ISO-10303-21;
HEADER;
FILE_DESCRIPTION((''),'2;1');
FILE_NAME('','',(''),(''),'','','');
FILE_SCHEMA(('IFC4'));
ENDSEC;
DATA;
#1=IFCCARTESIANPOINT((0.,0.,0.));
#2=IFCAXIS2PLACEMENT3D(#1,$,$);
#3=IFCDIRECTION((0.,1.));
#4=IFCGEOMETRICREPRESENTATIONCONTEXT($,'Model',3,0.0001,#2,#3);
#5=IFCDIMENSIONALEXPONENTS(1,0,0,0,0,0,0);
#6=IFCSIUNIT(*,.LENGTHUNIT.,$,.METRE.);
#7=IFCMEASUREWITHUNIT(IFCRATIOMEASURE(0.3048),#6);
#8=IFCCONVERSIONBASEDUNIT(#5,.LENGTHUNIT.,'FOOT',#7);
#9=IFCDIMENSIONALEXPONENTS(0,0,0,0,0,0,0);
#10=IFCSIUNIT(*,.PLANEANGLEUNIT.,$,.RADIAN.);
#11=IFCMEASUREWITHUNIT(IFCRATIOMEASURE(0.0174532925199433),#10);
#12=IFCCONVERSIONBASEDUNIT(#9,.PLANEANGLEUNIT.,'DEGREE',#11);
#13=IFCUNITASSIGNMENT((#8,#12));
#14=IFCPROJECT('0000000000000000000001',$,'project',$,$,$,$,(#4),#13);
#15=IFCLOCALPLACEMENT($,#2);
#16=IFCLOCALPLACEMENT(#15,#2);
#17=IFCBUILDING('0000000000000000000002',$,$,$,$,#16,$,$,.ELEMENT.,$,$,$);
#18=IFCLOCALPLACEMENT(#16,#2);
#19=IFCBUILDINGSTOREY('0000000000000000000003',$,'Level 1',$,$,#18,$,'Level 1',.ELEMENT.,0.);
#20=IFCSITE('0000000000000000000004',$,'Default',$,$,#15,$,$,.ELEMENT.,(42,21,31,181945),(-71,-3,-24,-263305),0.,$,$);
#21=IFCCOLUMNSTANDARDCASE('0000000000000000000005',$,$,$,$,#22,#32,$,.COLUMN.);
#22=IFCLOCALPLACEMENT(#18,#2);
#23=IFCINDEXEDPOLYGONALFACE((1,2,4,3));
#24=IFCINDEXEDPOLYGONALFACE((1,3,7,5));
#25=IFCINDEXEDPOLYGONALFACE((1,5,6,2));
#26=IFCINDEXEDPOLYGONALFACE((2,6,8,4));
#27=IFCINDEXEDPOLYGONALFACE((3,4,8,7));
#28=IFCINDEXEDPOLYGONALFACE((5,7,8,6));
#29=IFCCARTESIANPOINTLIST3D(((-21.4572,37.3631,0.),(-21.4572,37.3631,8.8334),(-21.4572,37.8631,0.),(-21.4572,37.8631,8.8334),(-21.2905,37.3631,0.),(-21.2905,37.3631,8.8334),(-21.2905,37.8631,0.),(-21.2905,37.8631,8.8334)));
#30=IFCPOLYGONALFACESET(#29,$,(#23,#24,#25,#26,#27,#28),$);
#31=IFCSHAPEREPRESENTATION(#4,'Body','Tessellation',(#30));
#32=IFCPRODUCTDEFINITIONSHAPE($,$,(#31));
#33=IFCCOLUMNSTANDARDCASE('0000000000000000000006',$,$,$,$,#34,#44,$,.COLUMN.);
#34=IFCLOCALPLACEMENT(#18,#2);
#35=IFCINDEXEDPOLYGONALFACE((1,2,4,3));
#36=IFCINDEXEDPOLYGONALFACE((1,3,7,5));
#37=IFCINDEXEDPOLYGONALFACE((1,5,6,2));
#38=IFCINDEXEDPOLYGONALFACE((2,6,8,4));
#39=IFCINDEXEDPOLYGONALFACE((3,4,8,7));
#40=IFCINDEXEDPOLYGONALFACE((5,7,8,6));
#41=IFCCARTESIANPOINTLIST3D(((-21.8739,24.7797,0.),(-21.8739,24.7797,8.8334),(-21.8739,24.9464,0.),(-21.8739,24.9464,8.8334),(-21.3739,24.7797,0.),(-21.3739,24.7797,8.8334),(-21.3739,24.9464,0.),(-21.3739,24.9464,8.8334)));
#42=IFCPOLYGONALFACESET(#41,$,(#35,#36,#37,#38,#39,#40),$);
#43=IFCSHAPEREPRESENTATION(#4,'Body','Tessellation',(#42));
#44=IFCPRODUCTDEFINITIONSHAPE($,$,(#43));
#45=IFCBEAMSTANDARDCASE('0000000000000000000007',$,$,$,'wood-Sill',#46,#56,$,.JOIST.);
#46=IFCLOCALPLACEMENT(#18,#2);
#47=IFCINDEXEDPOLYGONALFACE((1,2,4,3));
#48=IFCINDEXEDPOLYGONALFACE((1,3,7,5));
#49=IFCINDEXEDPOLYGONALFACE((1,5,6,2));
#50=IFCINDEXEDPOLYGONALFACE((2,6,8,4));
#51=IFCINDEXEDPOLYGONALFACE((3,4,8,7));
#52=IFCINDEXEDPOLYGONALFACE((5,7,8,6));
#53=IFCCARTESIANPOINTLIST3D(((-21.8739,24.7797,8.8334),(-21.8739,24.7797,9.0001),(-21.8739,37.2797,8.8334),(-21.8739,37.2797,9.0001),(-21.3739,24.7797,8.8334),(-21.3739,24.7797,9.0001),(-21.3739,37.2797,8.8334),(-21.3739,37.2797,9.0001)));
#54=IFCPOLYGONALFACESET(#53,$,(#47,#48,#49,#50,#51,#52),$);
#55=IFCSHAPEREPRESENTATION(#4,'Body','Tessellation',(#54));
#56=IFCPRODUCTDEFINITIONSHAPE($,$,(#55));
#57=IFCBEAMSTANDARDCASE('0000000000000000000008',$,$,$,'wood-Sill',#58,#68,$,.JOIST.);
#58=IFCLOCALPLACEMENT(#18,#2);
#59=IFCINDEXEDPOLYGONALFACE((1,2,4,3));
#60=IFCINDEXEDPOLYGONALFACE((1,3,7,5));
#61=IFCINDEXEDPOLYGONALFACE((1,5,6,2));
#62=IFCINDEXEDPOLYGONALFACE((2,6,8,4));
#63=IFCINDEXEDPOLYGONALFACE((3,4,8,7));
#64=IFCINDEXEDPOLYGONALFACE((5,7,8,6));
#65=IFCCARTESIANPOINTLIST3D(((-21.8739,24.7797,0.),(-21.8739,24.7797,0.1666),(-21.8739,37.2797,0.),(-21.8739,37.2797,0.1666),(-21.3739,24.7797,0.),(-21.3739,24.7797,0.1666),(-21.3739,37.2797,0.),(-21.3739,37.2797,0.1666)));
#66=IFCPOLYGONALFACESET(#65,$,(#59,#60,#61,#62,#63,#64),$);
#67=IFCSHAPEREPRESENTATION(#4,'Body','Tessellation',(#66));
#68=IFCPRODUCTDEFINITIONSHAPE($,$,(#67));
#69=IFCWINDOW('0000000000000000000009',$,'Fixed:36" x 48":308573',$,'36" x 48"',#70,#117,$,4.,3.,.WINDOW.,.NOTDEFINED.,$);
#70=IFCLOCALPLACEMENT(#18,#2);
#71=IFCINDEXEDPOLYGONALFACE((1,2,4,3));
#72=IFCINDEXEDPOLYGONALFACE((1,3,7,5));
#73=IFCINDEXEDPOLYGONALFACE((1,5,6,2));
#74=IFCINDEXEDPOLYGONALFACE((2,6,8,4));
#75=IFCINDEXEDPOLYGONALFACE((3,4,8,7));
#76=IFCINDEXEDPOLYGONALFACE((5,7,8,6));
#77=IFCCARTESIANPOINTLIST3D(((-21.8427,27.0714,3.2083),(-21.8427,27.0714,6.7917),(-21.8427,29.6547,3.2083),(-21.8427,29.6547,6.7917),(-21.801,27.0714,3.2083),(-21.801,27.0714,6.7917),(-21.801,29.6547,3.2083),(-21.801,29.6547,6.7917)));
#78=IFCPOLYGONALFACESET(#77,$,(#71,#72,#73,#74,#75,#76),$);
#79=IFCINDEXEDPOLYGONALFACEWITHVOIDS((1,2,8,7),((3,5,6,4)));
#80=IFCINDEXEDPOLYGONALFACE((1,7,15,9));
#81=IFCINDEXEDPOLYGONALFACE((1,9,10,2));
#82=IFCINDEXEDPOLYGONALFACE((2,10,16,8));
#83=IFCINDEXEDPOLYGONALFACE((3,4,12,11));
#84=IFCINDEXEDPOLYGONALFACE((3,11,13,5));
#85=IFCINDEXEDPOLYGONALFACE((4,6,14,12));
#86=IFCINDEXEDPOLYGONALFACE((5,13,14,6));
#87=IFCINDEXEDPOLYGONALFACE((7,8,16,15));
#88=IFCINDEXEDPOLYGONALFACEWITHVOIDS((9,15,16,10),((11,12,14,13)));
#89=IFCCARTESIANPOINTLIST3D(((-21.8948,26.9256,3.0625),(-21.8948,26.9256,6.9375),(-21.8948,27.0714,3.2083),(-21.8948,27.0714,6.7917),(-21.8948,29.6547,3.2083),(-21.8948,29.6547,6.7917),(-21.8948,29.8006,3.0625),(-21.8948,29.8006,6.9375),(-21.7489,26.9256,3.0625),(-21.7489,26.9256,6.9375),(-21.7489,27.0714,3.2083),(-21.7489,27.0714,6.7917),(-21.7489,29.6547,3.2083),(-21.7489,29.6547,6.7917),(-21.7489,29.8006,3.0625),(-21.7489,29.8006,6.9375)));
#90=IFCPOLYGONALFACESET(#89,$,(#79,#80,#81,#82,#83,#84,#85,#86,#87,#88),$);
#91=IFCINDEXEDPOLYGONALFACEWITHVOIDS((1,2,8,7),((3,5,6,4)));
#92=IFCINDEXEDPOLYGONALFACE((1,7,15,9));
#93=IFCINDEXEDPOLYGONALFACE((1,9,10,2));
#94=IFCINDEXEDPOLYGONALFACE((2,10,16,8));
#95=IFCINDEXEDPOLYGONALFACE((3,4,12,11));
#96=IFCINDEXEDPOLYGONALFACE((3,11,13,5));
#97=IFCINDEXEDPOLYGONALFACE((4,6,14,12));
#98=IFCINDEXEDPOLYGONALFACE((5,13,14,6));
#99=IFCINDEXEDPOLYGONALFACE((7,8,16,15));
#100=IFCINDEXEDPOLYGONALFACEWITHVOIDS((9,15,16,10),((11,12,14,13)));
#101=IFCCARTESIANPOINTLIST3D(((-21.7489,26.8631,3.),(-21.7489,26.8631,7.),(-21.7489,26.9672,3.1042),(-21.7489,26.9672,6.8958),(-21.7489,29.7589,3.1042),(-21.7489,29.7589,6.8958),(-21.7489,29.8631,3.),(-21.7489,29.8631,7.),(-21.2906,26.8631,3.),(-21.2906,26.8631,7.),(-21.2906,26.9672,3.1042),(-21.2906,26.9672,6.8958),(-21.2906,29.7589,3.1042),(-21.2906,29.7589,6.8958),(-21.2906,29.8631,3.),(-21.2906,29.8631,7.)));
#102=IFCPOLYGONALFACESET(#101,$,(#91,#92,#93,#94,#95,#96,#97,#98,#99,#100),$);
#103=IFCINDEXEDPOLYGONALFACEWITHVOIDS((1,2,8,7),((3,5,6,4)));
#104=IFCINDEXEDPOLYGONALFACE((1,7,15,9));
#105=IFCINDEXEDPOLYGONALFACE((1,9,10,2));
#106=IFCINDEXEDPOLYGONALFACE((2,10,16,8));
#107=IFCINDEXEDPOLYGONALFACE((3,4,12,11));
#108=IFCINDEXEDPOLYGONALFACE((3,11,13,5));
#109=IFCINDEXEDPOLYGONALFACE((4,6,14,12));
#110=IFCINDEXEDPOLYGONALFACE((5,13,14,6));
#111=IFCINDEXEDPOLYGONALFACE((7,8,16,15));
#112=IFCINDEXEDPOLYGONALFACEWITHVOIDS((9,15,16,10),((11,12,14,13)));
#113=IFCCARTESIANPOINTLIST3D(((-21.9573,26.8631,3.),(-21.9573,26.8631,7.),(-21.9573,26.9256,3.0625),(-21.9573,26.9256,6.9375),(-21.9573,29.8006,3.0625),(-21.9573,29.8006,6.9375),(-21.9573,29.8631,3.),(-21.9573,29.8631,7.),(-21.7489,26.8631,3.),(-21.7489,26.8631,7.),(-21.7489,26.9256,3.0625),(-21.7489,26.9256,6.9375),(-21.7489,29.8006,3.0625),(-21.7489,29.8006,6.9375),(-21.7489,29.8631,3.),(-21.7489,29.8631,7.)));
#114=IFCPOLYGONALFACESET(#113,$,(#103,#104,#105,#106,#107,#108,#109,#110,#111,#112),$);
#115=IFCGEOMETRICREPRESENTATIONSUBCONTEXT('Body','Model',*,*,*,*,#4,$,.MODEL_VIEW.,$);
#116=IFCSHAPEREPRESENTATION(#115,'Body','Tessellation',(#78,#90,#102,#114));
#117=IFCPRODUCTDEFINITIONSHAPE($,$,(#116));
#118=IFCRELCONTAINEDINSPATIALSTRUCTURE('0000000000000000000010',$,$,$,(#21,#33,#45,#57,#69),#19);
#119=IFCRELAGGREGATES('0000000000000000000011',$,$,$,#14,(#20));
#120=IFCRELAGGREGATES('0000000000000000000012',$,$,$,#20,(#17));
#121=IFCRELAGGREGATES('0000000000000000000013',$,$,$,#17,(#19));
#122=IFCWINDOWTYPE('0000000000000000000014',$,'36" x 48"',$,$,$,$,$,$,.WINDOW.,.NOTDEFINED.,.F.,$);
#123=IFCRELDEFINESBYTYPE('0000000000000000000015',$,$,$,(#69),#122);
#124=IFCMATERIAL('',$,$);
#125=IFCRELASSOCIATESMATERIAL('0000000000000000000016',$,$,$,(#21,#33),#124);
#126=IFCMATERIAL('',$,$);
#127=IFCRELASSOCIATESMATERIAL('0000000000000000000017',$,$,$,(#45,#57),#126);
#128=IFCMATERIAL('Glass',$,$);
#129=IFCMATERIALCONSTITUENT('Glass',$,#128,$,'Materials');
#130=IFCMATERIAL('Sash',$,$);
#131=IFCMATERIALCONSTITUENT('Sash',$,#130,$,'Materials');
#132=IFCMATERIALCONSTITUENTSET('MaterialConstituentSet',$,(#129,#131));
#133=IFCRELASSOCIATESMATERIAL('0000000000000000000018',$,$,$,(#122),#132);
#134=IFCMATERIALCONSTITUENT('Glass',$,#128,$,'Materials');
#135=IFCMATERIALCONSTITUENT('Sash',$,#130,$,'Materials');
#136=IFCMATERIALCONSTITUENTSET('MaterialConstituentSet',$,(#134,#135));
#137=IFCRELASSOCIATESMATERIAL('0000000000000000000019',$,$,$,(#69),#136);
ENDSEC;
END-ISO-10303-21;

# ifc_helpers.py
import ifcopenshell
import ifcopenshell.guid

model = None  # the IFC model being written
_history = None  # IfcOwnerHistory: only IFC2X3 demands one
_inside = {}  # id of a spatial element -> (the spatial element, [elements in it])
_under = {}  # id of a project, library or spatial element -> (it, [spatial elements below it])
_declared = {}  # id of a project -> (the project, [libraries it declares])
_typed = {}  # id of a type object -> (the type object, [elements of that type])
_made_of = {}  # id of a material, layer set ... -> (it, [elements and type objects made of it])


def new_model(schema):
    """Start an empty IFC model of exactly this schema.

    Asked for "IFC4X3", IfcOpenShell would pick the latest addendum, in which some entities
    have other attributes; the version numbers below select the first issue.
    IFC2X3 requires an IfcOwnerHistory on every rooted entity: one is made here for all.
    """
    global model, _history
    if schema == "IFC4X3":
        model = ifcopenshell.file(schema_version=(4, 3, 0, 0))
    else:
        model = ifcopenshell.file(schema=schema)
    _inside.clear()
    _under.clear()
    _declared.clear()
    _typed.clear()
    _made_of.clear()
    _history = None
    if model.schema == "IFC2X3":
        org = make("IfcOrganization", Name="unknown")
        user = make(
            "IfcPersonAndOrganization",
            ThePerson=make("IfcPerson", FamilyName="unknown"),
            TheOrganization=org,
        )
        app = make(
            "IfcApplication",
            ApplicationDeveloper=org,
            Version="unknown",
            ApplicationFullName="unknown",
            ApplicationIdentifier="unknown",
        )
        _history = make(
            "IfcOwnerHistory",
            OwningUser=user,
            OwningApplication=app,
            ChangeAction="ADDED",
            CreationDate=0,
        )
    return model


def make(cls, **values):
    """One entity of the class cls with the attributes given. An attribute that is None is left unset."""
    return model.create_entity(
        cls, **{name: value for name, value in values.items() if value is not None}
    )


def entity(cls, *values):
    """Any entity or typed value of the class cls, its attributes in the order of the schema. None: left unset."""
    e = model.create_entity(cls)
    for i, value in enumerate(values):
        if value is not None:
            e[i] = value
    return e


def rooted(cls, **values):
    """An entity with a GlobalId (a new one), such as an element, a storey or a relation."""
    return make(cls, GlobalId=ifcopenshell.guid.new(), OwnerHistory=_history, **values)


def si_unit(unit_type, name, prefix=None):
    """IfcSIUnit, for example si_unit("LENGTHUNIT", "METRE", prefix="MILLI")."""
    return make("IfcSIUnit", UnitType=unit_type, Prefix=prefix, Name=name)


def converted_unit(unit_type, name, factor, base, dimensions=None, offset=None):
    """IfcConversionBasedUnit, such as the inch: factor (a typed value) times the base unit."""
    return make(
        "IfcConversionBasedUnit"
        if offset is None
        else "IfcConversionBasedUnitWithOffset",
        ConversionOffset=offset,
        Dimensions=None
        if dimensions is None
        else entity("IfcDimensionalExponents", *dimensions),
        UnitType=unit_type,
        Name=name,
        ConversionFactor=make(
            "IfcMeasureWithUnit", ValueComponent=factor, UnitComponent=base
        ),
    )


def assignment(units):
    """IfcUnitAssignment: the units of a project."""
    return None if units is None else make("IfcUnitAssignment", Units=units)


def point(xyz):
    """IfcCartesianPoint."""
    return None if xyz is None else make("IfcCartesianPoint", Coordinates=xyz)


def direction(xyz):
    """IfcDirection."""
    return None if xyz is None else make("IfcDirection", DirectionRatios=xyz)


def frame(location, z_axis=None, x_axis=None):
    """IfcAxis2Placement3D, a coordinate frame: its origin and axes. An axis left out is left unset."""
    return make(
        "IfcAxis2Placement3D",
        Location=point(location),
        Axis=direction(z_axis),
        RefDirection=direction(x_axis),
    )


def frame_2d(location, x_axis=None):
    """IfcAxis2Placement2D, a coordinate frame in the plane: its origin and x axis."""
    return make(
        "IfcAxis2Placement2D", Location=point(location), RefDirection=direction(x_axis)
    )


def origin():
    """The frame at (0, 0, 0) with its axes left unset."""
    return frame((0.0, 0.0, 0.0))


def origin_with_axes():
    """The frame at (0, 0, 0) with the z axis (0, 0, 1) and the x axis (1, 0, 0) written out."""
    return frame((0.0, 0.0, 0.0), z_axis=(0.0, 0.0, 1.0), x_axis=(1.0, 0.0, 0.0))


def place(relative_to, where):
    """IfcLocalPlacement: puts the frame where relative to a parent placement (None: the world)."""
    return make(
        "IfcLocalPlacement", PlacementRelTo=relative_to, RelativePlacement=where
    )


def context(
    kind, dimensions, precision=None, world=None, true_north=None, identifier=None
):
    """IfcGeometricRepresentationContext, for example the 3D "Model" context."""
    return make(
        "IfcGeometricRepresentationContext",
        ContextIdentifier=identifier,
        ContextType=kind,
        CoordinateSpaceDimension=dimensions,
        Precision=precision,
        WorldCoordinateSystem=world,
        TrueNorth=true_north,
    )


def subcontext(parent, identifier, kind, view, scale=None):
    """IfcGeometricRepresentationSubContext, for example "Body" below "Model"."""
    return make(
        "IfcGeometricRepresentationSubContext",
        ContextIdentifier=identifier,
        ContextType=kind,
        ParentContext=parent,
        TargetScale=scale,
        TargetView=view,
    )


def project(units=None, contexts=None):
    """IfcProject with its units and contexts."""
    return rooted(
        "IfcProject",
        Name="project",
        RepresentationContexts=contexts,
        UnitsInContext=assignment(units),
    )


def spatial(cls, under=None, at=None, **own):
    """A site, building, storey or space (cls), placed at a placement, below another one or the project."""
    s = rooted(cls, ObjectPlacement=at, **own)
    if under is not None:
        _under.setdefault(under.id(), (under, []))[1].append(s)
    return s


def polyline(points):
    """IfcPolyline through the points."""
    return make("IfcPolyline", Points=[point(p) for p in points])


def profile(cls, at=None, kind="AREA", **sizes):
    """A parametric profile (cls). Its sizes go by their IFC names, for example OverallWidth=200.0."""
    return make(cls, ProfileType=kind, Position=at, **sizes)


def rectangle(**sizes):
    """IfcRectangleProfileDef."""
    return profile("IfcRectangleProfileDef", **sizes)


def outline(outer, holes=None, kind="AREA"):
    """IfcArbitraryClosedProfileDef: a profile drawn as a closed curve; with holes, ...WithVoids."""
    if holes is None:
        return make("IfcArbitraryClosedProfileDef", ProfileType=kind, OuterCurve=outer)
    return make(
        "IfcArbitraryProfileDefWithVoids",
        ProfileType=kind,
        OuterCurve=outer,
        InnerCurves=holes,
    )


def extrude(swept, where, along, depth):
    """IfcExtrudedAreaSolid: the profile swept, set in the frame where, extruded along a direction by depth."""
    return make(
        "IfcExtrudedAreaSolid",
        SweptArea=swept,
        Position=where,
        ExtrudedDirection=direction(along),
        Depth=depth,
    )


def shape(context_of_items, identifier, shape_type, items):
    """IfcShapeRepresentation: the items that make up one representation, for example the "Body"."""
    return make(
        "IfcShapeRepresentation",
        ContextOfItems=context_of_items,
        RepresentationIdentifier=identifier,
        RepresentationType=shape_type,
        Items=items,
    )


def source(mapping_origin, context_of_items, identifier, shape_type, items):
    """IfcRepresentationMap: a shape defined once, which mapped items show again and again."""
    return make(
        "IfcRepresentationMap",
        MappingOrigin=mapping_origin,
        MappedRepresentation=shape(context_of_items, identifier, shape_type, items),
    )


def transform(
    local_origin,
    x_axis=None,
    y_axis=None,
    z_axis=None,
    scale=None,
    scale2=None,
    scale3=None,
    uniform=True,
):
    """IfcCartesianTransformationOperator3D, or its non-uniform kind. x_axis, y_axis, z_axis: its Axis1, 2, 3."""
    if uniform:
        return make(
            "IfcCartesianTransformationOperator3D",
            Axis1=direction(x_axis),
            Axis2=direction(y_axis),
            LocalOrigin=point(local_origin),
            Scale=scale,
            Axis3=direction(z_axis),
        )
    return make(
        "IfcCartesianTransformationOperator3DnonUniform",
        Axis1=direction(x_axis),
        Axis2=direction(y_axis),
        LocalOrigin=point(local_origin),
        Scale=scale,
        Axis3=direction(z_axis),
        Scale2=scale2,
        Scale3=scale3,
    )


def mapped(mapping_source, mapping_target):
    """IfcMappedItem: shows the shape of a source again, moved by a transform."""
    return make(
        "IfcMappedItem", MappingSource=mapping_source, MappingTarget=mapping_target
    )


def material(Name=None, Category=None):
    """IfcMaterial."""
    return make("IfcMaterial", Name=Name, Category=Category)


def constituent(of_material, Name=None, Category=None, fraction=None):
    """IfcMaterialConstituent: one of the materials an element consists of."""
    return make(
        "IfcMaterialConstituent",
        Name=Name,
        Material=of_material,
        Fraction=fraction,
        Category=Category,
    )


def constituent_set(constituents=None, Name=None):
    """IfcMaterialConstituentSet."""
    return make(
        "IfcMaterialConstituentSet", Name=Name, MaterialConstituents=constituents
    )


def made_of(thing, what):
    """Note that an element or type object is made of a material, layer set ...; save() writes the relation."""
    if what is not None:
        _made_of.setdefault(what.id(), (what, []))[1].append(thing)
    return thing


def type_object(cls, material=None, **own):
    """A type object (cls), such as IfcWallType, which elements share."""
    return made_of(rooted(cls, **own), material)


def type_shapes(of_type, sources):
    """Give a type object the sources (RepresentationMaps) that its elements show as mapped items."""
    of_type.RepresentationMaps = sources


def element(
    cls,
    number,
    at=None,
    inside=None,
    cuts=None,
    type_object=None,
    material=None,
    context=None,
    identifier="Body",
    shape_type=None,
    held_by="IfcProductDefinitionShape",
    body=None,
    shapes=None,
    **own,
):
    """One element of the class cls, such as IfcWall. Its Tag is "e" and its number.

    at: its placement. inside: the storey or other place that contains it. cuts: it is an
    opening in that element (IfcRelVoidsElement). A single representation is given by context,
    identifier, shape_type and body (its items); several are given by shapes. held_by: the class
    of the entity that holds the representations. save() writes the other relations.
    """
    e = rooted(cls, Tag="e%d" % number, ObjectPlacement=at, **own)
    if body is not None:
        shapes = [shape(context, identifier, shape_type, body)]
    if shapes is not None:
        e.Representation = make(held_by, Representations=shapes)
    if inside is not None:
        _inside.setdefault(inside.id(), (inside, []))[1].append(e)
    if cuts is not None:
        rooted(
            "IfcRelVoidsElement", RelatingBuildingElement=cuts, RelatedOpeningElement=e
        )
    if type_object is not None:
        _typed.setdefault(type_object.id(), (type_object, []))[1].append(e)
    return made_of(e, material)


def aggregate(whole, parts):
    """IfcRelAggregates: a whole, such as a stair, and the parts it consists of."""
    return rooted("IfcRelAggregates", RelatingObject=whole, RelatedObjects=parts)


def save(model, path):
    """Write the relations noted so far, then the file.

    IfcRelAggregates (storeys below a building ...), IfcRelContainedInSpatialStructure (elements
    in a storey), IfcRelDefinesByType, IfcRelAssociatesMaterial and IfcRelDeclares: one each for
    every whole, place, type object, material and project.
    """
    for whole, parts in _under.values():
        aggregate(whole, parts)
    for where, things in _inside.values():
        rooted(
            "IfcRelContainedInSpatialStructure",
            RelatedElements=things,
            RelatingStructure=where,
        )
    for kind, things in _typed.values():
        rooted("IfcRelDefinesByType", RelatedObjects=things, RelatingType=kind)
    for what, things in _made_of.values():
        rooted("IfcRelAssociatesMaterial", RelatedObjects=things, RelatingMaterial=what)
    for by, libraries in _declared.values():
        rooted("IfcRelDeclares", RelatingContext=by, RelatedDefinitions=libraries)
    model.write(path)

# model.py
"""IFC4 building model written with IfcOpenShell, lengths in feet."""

from ifc_helpers import new_model, entity, si_unit, converted_unit, direction, frame, frame_2d, origin, origin_with_axes, place, context, subcontext, project, spatial, polyline, rectangle, outline, extrude, source, transform, mapped, material, constituent, constituent_set, type_object, type_shapes, element, save


model = new_model("IFC4")

# Units and contexts
model_context = context("Model", 3, precision=0.0001, world=origin(), true_north=direction((0.0, 1.0)))
body_context = subcontext(model_context, "Body", "Model", "MODEL_VIEW")
ifc_project = project(units=[converted_unit("LENGTHUNIT", "FOOT", entity("IfcRatioMeasure", 0.3048), si_unit("LENGTHUNIT", "METRE"), dimensions=[1, 0, 0, 0, 0, 0, 0]), converted_unit("PLANEANGLEUNIT", "DEGREE", entity("IfcRatioMeasure", 0.0174532925199433), si_unit("PLANEANGLEUNIT", "RADIAN"), dimensions=[0, 0, 0, 0, 0, 0, 0])], contexts=[model_context])

# Site, building, storey
site_placement = place(None, origin())
site = spatial("IfcSite", under=ifc_project, at=site_placement, Name="Default", CompositionType="ELEMENT", RefLatitude=(42, 21, 31, 181945), RefLongitude=(-71, -3, -24, -263305), RefElevation=0.0)
building_placement = place(site_placement, origin())
building = spatial("IfcBuilding", under=site, at=building_placement, CompositionType="ELEMENT")
storey_placement = place(building_placement, origin())
storey = spatial("IfcBuildingStorey", under=building, at=storey_placement, Name="Level 1", LongName="Level 1", CompositionType="ELEMENT", Elevation=0.0)

# Columns
ifc_material_1 = material(Name="")
placement_1 = place(storey_placement, frame((-21.2906, 37.6131, 0.0), z_axis=(0.0, 0.0, 1.0), x_axis=(-1.0, 0.0, 0.0)))
for number, where, z_axis, x_axis in (
    (1, (0.0833, 0.0, 0.0), (0.0, 0.0, 1.0), (1.0, 0.0, 0.0)),
):
    element("IfcColumnStandardCase", number, at=place(placement_1, frame(where, z_axis=z_axis, x_axis=x_axis)), inside=storey, material=ifc_material_1, PredefinedType="COLUMN", context=model_context, shape_type="SweptSolid", body=[
        extrude(rectangle(XDim=0.1667, YDim=0.5), origin(), (0.0, 0.0, 1.0), 8.8334),
    ])
placement_2 = place(storey_placement, frame((-21.6239, 24.7797, 0.0), z_axis=(0.0, 0.0, 1.0), x_axis=(0.0, 1.0, 0.0)))
for number, where, z_axis, x_axis in (
    (2, (0.0833, 0.0, 0.0), (0.0, 0.0, 1.0), (1.0, 0.0, 0.0)),
):
    element("IfcColumnStandardCase", number, at=place(placement_2, frame(where, z_axis=z_axis, x_axis=x_axis)), inside=storey, material=ifc_material_1, PredefinedType="COLUMN", context=model_context, shape_type="SweptSolid", body=[
        extrude(rectangle(XDim=0.1667, YDim=0.5), origin(), (0.0, 0.0, 1.0), 8.8334),
    ])

# Beams
ifc_material_2 = material(Name="")
for number, where, z_axis, x_axis in (
    (3, (0.0, 0.0, 8.9167), (1.0, 0.0, 0.0), (0.0, 0.0, 1.0)),
    (4, (0.0, 0.0, 0.0833), (1.0, 0.0, 0.0), (0.0, 0.0, 1.0)),
):
    element("IfcBeamStandardCase", number, at=place(placement_2, frame(where, z_axis=z_axis, x_axis=x_axis)), inside=storey, material=ifc_material_2, ObjectType="wood-Sill", PredefinedType="JOIST", context=model_context, shape_type="SweptSolid", body=[
        extrude(rectangle(XDim=0.1667, YDim=0.5), origin_with_axes(), (0.0, 0.0, 1.0), 12.5),
    ])

# Window
ifc_material_3 = material(Name="Glass")
ifc_constituent_1 = constituent(ifc_material_3, Name="Glass", Category="Materials")
ifc_material_4 = material(Name="Sash")
ifc_constituent_2 = constituent(ifc_material_4, Name="Sash", Category="Materials")
ifc_constituent_set_1 = constituent_set(constituents=[ifc_constituent_1, ifc_constituent_2], Name="MaterialConstituentSet")
ifc_constituent_3 = constituent(ifc_material_3, Name="Glass", Category="Materials")
ifc_constituent_4 = constituent(ifc_material_4, Name="Sash", Category="Materials")
ifc_constituent_set_2 = constituent_set(constituents=[ifc_constituent_3, ifc_constituent_4], Name="MaterialConstituentSet")
window_type = type_object("IfcWindowType", Name="36\" x 48\"", ParameterTakesPrecedence=False, PartitioningType="NOTDEFINED", PredefinedType="WINDOW", material=ifc_constituent_set_2)
shared_shape = source(origin(), body_context, "Body", "SweptSolid", [
    extrude(rectangle(XDim=2.5833, YDim=0.0417, at=frame_2d((0.0, 0.0), x_axis=(1.0, 0.0))), frame((1.75, 0.5312, 0.2083)), (0.0, 0.0, 1.0), 3.5833),
    extrude(outline(polyline([(-1.4375, -1.9375), (1.4375, -1.9375), (1.4375, 1.9375), (-1.4375, 1.9375), (-1.4375, -1.9375)]), holes=[polyline([(-1.2917, -1.7917), (-1.2917, 1.7917), (1.2917, 1.7917), (1.2917, -1.7917), (-1.2917, -1.7917)])]), frame((1.75, 0.6042, 2.0), z_axis=(0.0, -1.0, 0.0), x_axis=(-1.0, 0.0, 0.0)), (0.0, 0.0, 1.0), 0.1458),
    extrude(outline(polyline([(-1.5, -2.0), (1.5, -2.0), (1.5, 2.0), (-1.5, 2.0), (-1.5, -2.0)]), holes=[polyline([(-1.3958, -1.8958), (-1.3958, 1.8958), (1.3958, 1.8958), (1.3958, -1.8958), (-1.3958, -1.8958)])]), frame((1.75, 0.4583, 2.0), z_axis=(0.0, -1.0, 0.0), x_axis=(-1.0, 0.0, 0.0)), (0.0, 0.0, 1.0), 0.4583),
    extrude(outline(polyline([(-2.0, -1.5), (2.0, -1.5), (2.0, 1.5), (-2.0, 1.5), (-2.0, -1.5)]), holes=[polyline([(-1.9375, -1.4375), (-1.9375, 1.4375), (1.9375, 1.4375), (1.9375, -1.4375), (-1.9375, -1.4375)])]), frame((1.75, 0.6667, 2.0), z_axis=(0.0, -1.0, 0.0), x_axis=(0.0, 0.0, -1.0)), (0.0, 0.0, 1.0), 0.2083),
])
type_shapes(window_type, [shared_shape])
placement_3 = place(placement_2, frame((2.0833, -0.3333, 3.0)))
window_placement = place(placement_3, frame((-0.25, 0.0, 0.0)))
element("IfcWindow", 5, at=window_placement, inside=storey, type_object=window_type, material=ifc_constituent_set_1, Name="Fixed:36\" x 48\":308573", ObjectType="36\" x 48\"", OverallHeight=4.0, OverallWidth=3.0, PartitioningType="NOTDEFINED", PredefinedType="WINDOW", context=body_context, shape_type="MappedRepresentation", body=[
    mapped(shared_shape, transform((0.0, 0.0, 0.0), scale=1.0)),
])

save(model, "model.ifc")
